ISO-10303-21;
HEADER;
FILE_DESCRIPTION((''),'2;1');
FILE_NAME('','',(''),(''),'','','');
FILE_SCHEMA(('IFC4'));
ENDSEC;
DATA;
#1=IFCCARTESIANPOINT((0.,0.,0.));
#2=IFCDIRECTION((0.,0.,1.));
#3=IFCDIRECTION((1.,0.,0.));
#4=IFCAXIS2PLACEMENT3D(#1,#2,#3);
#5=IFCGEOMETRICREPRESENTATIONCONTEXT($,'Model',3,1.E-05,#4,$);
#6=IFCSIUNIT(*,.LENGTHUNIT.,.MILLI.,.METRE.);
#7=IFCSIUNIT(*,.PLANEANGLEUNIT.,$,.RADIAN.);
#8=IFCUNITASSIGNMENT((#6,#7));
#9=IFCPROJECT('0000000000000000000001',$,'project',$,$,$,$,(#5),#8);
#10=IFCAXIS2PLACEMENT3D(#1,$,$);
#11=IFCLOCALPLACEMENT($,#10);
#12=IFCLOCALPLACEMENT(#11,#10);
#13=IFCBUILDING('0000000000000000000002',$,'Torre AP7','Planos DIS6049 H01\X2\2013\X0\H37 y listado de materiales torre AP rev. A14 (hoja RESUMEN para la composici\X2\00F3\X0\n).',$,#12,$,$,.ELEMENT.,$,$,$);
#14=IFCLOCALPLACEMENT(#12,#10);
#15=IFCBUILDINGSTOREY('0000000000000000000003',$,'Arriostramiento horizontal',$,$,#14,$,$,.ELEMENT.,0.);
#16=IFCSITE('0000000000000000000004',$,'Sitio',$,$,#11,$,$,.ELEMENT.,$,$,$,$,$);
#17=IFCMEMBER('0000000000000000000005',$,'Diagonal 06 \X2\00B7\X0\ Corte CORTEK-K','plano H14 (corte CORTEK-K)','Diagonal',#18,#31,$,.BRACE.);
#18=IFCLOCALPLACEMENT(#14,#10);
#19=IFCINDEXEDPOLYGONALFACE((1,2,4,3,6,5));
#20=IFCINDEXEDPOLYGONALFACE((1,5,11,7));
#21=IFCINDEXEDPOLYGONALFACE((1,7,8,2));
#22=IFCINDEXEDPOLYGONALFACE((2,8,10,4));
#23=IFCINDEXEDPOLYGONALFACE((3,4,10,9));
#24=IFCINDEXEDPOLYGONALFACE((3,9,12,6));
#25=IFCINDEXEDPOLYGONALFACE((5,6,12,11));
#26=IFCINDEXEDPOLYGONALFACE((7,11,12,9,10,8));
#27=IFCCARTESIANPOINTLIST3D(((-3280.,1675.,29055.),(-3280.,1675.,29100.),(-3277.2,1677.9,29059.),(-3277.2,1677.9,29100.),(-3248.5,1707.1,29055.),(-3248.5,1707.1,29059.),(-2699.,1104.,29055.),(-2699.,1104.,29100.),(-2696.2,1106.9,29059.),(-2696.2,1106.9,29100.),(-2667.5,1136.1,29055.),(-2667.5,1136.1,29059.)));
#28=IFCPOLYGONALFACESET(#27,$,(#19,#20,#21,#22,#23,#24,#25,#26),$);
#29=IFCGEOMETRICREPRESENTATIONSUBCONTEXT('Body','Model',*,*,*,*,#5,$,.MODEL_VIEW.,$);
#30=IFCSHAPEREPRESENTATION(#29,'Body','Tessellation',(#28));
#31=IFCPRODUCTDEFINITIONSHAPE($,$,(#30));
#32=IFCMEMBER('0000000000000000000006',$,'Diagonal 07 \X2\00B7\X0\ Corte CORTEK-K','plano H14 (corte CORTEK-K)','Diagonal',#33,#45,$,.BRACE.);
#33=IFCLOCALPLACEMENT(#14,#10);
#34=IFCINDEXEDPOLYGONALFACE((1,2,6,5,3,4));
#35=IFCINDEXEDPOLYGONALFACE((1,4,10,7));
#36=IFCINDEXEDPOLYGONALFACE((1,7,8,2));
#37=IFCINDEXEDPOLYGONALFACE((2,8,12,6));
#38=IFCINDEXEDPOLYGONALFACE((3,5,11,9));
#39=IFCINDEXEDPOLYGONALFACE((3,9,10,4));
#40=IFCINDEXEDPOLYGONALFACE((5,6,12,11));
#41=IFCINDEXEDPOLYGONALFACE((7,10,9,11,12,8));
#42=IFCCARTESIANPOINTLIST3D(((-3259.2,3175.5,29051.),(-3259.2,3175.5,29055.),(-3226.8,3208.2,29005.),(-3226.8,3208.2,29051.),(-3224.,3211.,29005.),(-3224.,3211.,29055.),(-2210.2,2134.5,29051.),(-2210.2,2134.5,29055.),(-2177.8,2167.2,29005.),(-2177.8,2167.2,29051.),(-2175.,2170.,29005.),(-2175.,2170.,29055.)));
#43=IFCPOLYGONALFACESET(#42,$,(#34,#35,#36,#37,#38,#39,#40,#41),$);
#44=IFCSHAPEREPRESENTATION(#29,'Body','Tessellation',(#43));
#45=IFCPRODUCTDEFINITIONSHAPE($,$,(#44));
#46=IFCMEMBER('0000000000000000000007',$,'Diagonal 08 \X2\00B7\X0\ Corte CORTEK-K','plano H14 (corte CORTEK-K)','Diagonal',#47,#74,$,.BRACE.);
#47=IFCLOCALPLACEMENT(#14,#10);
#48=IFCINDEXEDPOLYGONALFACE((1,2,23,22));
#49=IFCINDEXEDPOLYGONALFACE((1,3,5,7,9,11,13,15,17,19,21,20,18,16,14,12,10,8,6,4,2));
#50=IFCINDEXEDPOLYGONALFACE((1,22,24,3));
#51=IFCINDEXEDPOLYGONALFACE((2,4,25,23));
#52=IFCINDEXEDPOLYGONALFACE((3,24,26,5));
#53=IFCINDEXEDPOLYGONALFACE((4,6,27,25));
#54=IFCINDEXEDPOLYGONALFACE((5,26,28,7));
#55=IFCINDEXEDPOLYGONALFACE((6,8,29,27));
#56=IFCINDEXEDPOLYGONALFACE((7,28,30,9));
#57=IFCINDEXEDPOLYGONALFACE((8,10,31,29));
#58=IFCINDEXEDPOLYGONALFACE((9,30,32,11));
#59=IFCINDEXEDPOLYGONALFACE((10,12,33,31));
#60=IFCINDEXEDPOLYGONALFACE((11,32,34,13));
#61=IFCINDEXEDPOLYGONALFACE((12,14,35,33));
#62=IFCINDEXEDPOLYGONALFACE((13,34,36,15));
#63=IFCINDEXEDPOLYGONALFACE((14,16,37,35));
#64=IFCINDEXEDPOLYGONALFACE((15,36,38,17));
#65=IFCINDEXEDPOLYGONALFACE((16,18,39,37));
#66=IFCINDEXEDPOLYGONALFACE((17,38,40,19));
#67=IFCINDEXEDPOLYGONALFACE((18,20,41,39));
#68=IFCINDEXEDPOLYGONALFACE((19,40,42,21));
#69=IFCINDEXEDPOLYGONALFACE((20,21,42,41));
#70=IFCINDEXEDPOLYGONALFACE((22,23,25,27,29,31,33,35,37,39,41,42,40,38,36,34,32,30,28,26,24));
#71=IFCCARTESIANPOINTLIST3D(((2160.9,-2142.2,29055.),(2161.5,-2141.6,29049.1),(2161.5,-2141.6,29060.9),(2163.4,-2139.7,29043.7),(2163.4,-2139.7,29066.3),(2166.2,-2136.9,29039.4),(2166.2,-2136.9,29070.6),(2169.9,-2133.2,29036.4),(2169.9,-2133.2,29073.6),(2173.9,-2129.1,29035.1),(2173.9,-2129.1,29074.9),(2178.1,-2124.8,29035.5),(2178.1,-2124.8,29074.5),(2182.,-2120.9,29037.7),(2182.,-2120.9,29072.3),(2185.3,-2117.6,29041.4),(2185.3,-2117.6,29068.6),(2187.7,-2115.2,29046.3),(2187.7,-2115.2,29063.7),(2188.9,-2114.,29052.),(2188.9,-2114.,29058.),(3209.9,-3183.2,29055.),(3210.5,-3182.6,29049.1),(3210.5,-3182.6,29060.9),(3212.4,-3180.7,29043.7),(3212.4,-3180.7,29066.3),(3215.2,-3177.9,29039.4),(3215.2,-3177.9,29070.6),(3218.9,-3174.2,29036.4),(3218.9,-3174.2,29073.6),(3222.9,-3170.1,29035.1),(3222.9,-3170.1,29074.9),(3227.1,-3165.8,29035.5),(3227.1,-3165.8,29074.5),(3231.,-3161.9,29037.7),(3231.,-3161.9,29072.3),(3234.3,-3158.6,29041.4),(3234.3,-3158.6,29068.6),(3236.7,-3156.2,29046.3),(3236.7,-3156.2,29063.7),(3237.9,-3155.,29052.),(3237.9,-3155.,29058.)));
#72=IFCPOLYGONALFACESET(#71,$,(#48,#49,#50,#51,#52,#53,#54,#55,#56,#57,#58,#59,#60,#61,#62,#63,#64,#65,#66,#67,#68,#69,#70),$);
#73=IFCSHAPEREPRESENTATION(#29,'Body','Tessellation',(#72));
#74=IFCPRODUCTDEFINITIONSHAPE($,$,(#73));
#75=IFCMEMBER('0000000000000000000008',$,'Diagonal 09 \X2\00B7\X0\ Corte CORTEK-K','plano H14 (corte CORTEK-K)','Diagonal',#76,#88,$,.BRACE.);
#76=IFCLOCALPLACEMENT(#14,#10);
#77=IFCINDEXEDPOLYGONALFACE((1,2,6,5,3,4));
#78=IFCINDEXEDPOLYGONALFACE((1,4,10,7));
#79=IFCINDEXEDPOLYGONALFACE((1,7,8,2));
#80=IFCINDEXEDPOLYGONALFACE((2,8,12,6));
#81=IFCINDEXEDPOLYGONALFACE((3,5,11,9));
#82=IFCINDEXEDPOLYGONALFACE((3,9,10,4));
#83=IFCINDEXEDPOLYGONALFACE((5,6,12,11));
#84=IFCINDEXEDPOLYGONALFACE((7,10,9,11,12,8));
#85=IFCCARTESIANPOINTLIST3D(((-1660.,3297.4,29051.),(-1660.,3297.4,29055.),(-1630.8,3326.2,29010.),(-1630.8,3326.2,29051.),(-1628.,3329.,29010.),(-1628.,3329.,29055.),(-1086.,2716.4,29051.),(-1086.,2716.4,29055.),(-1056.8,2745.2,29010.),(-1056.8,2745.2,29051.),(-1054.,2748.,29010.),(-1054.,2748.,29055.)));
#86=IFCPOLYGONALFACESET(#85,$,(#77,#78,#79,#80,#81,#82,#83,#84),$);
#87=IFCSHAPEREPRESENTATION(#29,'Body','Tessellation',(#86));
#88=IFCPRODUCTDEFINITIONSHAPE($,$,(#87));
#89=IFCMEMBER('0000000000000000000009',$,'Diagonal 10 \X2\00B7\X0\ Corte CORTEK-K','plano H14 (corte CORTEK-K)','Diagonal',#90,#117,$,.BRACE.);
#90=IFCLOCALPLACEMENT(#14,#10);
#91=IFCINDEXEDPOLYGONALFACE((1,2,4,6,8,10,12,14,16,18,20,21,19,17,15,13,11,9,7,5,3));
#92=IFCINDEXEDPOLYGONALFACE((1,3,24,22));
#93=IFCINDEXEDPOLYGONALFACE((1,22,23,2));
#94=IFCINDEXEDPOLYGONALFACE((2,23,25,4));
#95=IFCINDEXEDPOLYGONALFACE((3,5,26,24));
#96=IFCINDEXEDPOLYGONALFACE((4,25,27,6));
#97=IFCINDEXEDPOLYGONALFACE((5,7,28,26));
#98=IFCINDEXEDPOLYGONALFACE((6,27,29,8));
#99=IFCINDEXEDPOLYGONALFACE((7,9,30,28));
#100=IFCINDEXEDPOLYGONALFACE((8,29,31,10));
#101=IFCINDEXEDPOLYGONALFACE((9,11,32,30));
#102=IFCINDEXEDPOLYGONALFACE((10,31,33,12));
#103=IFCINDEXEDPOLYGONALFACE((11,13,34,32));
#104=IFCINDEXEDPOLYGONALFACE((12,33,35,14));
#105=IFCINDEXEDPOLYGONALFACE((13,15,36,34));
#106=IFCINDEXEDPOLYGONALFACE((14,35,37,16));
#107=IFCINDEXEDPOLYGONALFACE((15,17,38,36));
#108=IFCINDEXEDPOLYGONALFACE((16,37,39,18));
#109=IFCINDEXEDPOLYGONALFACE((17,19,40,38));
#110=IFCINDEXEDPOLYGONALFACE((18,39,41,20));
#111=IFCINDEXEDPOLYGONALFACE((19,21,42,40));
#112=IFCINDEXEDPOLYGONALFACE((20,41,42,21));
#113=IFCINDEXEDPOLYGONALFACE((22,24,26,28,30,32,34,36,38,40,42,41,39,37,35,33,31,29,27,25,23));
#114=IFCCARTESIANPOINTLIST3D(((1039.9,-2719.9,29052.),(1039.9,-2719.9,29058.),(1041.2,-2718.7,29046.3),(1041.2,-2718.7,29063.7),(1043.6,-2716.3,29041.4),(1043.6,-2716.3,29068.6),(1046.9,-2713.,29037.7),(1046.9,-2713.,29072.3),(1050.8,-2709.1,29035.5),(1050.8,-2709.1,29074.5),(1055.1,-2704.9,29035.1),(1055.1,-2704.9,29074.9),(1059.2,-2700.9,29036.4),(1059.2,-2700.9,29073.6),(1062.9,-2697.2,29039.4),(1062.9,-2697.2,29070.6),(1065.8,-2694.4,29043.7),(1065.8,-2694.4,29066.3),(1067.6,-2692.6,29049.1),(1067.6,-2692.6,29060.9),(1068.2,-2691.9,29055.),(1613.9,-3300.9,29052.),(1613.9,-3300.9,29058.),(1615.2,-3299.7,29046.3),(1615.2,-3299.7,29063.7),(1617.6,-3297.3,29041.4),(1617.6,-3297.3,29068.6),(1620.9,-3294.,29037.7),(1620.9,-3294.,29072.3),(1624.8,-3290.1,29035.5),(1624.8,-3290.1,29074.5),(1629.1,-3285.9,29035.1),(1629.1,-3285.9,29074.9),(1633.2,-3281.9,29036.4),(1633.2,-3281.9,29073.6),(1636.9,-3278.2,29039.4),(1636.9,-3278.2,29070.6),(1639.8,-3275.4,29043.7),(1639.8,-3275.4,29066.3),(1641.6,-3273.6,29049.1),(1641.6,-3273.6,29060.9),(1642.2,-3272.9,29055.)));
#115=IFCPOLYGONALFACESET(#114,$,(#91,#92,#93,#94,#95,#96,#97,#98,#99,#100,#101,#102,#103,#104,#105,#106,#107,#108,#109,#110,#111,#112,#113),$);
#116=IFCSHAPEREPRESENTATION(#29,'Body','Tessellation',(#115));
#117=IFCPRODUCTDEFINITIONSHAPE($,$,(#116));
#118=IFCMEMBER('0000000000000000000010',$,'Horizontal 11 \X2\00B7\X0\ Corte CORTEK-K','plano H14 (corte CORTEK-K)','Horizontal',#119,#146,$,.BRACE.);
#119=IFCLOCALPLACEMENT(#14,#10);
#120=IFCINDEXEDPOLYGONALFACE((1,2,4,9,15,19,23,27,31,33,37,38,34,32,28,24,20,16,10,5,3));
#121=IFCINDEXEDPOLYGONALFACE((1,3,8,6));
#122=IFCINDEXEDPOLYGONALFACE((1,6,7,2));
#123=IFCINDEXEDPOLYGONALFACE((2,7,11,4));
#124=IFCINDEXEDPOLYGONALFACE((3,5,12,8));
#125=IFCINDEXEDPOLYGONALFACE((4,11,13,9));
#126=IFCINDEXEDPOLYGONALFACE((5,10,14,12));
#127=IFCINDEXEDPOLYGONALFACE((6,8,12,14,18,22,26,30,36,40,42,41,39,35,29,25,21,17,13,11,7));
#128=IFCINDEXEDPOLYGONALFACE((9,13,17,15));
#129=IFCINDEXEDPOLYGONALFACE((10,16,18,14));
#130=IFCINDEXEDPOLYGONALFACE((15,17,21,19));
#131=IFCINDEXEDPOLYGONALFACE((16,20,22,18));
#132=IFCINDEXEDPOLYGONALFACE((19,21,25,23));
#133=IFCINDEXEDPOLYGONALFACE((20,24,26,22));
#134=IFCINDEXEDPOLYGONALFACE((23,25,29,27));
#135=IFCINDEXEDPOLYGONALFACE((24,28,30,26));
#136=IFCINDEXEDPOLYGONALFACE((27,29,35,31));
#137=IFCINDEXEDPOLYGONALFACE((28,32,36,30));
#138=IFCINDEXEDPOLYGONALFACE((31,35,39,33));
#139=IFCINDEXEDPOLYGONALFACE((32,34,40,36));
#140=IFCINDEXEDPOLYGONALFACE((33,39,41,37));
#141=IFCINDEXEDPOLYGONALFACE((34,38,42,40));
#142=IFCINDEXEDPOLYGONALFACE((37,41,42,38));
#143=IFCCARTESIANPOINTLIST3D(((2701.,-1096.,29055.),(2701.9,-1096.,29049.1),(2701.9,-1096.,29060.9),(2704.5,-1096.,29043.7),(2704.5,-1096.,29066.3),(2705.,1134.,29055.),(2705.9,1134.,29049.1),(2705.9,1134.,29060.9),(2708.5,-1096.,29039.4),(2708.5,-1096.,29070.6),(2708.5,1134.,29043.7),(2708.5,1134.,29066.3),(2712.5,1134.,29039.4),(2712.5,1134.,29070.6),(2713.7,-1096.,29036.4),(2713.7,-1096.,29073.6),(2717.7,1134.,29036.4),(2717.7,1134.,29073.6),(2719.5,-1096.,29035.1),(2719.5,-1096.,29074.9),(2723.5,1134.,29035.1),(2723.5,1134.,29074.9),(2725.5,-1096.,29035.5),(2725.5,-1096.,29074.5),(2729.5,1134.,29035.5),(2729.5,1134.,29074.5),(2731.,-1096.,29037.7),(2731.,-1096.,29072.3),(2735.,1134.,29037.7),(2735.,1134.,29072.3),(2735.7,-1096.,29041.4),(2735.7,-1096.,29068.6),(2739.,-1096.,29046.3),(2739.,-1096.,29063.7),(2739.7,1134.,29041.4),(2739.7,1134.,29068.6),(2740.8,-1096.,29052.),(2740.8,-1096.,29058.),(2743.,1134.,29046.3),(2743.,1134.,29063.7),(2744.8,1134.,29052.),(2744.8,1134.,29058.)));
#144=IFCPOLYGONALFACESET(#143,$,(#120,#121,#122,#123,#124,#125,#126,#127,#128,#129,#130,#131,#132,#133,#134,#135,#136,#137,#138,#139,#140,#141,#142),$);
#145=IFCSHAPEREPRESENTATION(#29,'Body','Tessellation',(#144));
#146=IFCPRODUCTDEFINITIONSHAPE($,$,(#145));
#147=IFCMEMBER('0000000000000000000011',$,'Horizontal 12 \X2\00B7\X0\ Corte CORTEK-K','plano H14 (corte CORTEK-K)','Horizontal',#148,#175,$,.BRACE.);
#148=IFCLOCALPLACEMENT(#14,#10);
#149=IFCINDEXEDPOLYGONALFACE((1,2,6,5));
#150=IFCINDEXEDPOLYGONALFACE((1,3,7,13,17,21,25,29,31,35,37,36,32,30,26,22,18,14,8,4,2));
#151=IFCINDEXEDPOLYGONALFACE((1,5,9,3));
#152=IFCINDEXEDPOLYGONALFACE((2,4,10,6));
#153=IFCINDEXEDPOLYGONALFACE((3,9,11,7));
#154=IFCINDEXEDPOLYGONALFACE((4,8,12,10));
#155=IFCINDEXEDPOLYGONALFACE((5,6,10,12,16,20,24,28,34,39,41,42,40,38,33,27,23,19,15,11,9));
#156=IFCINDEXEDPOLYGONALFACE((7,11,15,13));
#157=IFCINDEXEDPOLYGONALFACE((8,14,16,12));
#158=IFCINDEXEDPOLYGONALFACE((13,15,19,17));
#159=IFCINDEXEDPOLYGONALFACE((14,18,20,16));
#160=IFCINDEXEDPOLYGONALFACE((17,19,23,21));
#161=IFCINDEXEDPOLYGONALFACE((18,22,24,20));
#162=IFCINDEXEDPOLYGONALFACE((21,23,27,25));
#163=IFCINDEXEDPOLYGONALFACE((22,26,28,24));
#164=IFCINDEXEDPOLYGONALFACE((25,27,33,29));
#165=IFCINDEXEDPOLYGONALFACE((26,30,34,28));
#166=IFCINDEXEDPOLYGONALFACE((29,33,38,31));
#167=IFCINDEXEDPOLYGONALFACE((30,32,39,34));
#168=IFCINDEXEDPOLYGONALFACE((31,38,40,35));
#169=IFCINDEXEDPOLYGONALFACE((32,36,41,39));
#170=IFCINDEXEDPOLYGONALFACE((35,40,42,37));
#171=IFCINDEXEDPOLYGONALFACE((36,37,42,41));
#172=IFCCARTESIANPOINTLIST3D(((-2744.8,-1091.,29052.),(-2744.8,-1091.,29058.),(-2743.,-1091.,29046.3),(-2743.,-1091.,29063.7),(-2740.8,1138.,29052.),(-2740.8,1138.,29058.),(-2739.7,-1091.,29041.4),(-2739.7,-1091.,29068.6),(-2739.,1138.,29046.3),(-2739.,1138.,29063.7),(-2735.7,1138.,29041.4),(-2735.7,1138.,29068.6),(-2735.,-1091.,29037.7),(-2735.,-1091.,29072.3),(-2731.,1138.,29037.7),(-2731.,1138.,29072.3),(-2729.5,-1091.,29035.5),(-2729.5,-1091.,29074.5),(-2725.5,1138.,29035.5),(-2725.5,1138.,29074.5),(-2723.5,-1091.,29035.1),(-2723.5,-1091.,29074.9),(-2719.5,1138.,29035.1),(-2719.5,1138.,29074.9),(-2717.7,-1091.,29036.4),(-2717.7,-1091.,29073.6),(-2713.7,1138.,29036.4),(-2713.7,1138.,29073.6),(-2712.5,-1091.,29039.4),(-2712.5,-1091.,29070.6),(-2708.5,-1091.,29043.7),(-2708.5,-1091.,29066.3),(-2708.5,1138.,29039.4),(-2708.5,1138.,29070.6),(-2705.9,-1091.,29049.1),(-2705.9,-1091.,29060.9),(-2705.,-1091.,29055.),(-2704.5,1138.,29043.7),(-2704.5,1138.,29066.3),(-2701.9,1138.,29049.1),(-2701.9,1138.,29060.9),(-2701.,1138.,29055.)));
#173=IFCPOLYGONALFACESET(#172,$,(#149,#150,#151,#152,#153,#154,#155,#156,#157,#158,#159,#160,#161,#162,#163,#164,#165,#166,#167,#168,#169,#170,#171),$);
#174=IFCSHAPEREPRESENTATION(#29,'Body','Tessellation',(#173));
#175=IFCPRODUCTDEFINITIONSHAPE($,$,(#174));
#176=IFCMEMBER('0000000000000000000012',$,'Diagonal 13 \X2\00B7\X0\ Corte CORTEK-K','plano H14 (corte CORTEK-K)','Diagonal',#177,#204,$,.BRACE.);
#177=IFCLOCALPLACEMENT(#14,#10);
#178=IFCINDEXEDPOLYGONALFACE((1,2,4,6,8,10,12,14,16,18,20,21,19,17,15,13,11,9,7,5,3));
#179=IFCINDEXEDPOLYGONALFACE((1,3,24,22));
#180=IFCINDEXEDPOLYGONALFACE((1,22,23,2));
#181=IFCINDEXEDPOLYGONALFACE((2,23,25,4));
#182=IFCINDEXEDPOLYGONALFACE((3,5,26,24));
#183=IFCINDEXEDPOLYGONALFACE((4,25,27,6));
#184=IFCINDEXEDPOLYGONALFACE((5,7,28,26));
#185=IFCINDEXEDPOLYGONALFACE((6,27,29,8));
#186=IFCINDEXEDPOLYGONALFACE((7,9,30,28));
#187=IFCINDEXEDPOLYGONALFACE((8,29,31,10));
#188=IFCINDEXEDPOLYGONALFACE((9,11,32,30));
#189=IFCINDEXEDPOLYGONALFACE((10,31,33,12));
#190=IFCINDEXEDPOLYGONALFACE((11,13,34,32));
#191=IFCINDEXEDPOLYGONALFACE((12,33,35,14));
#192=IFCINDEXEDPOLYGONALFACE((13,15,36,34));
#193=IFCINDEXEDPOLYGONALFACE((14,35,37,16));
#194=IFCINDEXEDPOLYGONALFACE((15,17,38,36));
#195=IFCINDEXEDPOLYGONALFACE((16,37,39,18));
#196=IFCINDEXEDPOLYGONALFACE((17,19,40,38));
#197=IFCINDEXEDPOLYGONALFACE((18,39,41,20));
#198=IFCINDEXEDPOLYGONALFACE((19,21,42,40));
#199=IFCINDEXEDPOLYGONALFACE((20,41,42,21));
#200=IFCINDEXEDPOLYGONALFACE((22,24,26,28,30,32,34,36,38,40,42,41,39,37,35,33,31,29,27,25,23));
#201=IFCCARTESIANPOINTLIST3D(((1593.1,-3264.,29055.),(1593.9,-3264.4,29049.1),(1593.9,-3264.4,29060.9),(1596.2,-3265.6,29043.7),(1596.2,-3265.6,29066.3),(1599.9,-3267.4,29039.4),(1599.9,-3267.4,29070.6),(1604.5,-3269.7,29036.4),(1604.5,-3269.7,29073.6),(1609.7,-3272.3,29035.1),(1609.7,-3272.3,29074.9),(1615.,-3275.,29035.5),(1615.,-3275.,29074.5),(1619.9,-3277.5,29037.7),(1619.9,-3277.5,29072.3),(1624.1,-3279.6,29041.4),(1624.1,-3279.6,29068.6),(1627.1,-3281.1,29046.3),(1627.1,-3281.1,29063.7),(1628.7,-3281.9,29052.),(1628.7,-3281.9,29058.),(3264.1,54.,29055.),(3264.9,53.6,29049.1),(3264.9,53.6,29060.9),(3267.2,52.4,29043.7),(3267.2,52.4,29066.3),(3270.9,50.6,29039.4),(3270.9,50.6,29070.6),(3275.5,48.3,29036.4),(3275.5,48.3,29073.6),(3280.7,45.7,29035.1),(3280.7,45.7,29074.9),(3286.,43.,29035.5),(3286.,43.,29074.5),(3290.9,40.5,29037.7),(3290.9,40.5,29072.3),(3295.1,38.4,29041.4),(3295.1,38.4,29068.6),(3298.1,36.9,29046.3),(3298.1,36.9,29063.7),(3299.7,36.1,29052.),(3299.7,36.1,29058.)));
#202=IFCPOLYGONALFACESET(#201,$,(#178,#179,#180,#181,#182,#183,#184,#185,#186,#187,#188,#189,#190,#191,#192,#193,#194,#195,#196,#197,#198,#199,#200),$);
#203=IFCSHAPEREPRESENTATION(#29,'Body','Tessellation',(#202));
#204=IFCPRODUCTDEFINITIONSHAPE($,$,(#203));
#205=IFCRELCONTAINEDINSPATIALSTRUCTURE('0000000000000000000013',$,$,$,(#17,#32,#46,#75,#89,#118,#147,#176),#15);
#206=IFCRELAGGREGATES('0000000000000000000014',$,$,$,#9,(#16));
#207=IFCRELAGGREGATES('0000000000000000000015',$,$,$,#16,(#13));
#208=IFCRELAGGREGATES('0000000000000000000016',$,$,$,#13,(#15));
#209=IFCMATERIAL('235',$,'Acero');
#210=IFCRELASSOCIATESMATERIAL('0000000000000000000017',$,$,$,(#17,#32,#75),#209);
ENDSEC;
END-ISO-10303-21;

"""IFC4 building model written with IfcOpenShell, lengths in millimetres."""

from ifc_helpers import new_model, si_unit, frame, frame_2d, origin, origin_with_axes, place, context, subcontext, project, spatial, circle, l_section, extrude, material, element, save


model = new_model("IFC4")

# Units and contexts
model_context = context("Model", 3, precision=1e-05, world=origin_with_axes())
body_context = subcontext(model_context, "Body", "Model", "MODEL_VIEW")
ifc_project = project(units=[si_unit("LENGTHUNIT", "METRE", prefix="MILLI"), si_unit("PLANEANGLEUNIT", "RADIAN")], contexts=[model_context])

# Site, building, storey
site_placement = place(None, origin())
site = spatial("IfcSite", under=ifc_project, at=site_placement, Name="Sitio", CompositionType="ELEMENT")
building_placement = place(site_placement, origin())
building = spatial("IfcBuilding", under=site, at=building_placement, Name="Torre AP7", Description="Planos DIS6049 H01–H37 y listado de materiales torre AP rev. A14 (hoja RESUMEN para la composición).", CompositionType="ELEMENT")
storey_placement = place(building_placement, origin())
storey = spatial("IfcBuildingStorey", under=building, at=storey_placement, Name="Arriostramiento horizontal", CompositionType="ELEMENT", Elevation=0.0)

# Members
ifc_material = material(Name="235", Category="Acero")
member_1_placement = place(storey_placement, frame((-3280.0, 1675.0, 29055.0), z_axis=(0.713218, -0.700942, 0.0), x_axis=(0.700942, 0.713218, 0.0)))
element("IfcMember", 1, at=member_1_placement, inside=storey, material=ifc_material, Name="Diagonal 06 · Corte CORTEK-K", Description="plano H14 (corte CORTEK-K)", ObjectType="Diagonal", PredefinedType="BRACE", context=body_context, shape_type="SweptSolid", body=[
    extrude(l_section(Depth=45.0, Width=45.0, Thickness=4.0, at=frame_2d((22.5, 22.5))), None, (0.0, 0.0, 1.0), 814.6),
])
member_2_placement = place(storey_placement, frame((-3224.0, 3211.0, 29055.0), z_axis=(0.709808, -0.704395, 0.0), x_axis=(-0.704395, -0.709808, 0.0)))
element("IfcMember", 2, at=member_2_placement, inside=storey, material=ifc_material, Name="Diagonal 07 · Corte CORTEK-K", Description="plano H14 (corte CORTEK-K)", ObjectType="Diagonal", PredefinedType="BRACE", context=body_context, shape_type="SweptSolid", body=[
    extrude(l_section(Depth=50.0, Width=50.0, Thickness=4.0, at=frame_2d((25.0, 25.0))), None, (0.0, 0.0, 1.0), 1477.9),
])
member_3_placement = place(storey_placement, frame((2175.0, -2128.0, 29055.0), z_axis=(0.709808, -0.704395, 0.0), x_axis=(-0.704395, -0.709808, 0.0)))
element("IfcMember", 3, at=member_3_placement, inside=storey, Name="Diagonal 08 · Corte CORTEK-K", Description="plano H14 (corte CORTEK-K)", ObjectType="Diagonal", PredefinedType="BRACE", context=body_context, shape_type="SweptSolid", body=[
    extrude(circle(Radius=20.0), None, (0.0, 0.0, 1.0), 1477.9),
])
member_4_placement = place(storey_placement, frame((-1628.0, 3329.0, 29055.0), z_axis=(0.702808, -0.711379, 0.0), x_axis=(-0.711379, -0.702808, 0.0)))
element("IfcMember", 4, at=member_4_placement, inside=storey, material=ifc_material, Name="Diagonal 09 · Corte CORTEK-K", Description="plano H14 (corte CORTEK-K)", ObjectType="Diagonal", PredefinedType="BRACE", context=body_context, shape_type="SweptSolid", body=[
    extrude(l_section(Depth=45.0, Width=45.0, Thickness=4.0, at=frame_2d((22.5, 22.5))), None, (0.0, 0.0, 1.0), 816.7),
])
member_5_placement = place(storey_placement, frame((1054.0, -2706.0, 29055.0), z_axis=(0.702808, -0.711379, 0.0), x_axis=(0.711379, 0.702808, 0.0)))
element("IfcMember", 5, at=member_5_placement, inside=storey, Name="Diagonal 10 · Corte CORTEK-K", Description="plano H14 (corte CORTEK-K)", ObjectType="Diagonal", PredefinedType="BRACE", context=body_context, shape_type="SweptSolid", body=[
    extrude(circle(Radius=20.0), None, (0.0, 0.0, 1.0), 816.7),
])
member_6_placement = place(storey_placement, frame((2725.0, 1134.0, 29055.0), z_axis=(-0.001794, -0.999998, 0.0), x_axis=(-0.999998, 0.001794, 0.0)))
element("IfcMember", 6, at=member_6_placement, inside=storey, Name="Horizontal 11 · Corte CORTEK-K", Description="plano H14 (corte CORTEK-K)", ObjectType="Horizontal", PredefinedType="BRACE", context=body_context, shape_type="SweptSolid", body=[
    extrude(circle(Radius=20.0), None, (0.0, 0.0, 1.0), 2230.0),
])
member_7_placement = place(storey_placement, frame((-2721.0, 1138.0, 29055.0), z_axis=(-0.001795, -0.999998, 0.0), x_axis=(0.999998, -0.001795, 0.0)))
element("IfcMember", 7, at=member_7_placement, inside=storey, Name="Horizontal 12 · Corte CORTEK-K", Description="plano H14 (corte CORTEK-K)", ObjectType="Horizontal", PredefinedType="BRACE", context=body_context, shape_type="SweptSolid", body=[
    extrude(circle(Radius=20.0), None, (0.0, 0.0, 1.0), 2229.0),
])
member_8_placement = place(storey_placement, frame((3282.0, 45.0, 29055.0), z_axis=(-0.449796, -0.893131, 0.0), x_axis=(-0.893131, 0.449796, 0.0)))
element("IfcMember", 8, at=member_8_placement, inside=storey, Name="Diagonal 13 · Corte CORTEK-K", Description="plano H14 (corte CORTEK-K)", ObjectType="Diagonal", PredefinedType="BRACE", context=body_context, shape_type="SweptSolid", body=[
    extrude(circle(Radius=20.0), None, (0.0, 0.0, 1.0), 3715.0),
])

save(model, "model.ifc")
